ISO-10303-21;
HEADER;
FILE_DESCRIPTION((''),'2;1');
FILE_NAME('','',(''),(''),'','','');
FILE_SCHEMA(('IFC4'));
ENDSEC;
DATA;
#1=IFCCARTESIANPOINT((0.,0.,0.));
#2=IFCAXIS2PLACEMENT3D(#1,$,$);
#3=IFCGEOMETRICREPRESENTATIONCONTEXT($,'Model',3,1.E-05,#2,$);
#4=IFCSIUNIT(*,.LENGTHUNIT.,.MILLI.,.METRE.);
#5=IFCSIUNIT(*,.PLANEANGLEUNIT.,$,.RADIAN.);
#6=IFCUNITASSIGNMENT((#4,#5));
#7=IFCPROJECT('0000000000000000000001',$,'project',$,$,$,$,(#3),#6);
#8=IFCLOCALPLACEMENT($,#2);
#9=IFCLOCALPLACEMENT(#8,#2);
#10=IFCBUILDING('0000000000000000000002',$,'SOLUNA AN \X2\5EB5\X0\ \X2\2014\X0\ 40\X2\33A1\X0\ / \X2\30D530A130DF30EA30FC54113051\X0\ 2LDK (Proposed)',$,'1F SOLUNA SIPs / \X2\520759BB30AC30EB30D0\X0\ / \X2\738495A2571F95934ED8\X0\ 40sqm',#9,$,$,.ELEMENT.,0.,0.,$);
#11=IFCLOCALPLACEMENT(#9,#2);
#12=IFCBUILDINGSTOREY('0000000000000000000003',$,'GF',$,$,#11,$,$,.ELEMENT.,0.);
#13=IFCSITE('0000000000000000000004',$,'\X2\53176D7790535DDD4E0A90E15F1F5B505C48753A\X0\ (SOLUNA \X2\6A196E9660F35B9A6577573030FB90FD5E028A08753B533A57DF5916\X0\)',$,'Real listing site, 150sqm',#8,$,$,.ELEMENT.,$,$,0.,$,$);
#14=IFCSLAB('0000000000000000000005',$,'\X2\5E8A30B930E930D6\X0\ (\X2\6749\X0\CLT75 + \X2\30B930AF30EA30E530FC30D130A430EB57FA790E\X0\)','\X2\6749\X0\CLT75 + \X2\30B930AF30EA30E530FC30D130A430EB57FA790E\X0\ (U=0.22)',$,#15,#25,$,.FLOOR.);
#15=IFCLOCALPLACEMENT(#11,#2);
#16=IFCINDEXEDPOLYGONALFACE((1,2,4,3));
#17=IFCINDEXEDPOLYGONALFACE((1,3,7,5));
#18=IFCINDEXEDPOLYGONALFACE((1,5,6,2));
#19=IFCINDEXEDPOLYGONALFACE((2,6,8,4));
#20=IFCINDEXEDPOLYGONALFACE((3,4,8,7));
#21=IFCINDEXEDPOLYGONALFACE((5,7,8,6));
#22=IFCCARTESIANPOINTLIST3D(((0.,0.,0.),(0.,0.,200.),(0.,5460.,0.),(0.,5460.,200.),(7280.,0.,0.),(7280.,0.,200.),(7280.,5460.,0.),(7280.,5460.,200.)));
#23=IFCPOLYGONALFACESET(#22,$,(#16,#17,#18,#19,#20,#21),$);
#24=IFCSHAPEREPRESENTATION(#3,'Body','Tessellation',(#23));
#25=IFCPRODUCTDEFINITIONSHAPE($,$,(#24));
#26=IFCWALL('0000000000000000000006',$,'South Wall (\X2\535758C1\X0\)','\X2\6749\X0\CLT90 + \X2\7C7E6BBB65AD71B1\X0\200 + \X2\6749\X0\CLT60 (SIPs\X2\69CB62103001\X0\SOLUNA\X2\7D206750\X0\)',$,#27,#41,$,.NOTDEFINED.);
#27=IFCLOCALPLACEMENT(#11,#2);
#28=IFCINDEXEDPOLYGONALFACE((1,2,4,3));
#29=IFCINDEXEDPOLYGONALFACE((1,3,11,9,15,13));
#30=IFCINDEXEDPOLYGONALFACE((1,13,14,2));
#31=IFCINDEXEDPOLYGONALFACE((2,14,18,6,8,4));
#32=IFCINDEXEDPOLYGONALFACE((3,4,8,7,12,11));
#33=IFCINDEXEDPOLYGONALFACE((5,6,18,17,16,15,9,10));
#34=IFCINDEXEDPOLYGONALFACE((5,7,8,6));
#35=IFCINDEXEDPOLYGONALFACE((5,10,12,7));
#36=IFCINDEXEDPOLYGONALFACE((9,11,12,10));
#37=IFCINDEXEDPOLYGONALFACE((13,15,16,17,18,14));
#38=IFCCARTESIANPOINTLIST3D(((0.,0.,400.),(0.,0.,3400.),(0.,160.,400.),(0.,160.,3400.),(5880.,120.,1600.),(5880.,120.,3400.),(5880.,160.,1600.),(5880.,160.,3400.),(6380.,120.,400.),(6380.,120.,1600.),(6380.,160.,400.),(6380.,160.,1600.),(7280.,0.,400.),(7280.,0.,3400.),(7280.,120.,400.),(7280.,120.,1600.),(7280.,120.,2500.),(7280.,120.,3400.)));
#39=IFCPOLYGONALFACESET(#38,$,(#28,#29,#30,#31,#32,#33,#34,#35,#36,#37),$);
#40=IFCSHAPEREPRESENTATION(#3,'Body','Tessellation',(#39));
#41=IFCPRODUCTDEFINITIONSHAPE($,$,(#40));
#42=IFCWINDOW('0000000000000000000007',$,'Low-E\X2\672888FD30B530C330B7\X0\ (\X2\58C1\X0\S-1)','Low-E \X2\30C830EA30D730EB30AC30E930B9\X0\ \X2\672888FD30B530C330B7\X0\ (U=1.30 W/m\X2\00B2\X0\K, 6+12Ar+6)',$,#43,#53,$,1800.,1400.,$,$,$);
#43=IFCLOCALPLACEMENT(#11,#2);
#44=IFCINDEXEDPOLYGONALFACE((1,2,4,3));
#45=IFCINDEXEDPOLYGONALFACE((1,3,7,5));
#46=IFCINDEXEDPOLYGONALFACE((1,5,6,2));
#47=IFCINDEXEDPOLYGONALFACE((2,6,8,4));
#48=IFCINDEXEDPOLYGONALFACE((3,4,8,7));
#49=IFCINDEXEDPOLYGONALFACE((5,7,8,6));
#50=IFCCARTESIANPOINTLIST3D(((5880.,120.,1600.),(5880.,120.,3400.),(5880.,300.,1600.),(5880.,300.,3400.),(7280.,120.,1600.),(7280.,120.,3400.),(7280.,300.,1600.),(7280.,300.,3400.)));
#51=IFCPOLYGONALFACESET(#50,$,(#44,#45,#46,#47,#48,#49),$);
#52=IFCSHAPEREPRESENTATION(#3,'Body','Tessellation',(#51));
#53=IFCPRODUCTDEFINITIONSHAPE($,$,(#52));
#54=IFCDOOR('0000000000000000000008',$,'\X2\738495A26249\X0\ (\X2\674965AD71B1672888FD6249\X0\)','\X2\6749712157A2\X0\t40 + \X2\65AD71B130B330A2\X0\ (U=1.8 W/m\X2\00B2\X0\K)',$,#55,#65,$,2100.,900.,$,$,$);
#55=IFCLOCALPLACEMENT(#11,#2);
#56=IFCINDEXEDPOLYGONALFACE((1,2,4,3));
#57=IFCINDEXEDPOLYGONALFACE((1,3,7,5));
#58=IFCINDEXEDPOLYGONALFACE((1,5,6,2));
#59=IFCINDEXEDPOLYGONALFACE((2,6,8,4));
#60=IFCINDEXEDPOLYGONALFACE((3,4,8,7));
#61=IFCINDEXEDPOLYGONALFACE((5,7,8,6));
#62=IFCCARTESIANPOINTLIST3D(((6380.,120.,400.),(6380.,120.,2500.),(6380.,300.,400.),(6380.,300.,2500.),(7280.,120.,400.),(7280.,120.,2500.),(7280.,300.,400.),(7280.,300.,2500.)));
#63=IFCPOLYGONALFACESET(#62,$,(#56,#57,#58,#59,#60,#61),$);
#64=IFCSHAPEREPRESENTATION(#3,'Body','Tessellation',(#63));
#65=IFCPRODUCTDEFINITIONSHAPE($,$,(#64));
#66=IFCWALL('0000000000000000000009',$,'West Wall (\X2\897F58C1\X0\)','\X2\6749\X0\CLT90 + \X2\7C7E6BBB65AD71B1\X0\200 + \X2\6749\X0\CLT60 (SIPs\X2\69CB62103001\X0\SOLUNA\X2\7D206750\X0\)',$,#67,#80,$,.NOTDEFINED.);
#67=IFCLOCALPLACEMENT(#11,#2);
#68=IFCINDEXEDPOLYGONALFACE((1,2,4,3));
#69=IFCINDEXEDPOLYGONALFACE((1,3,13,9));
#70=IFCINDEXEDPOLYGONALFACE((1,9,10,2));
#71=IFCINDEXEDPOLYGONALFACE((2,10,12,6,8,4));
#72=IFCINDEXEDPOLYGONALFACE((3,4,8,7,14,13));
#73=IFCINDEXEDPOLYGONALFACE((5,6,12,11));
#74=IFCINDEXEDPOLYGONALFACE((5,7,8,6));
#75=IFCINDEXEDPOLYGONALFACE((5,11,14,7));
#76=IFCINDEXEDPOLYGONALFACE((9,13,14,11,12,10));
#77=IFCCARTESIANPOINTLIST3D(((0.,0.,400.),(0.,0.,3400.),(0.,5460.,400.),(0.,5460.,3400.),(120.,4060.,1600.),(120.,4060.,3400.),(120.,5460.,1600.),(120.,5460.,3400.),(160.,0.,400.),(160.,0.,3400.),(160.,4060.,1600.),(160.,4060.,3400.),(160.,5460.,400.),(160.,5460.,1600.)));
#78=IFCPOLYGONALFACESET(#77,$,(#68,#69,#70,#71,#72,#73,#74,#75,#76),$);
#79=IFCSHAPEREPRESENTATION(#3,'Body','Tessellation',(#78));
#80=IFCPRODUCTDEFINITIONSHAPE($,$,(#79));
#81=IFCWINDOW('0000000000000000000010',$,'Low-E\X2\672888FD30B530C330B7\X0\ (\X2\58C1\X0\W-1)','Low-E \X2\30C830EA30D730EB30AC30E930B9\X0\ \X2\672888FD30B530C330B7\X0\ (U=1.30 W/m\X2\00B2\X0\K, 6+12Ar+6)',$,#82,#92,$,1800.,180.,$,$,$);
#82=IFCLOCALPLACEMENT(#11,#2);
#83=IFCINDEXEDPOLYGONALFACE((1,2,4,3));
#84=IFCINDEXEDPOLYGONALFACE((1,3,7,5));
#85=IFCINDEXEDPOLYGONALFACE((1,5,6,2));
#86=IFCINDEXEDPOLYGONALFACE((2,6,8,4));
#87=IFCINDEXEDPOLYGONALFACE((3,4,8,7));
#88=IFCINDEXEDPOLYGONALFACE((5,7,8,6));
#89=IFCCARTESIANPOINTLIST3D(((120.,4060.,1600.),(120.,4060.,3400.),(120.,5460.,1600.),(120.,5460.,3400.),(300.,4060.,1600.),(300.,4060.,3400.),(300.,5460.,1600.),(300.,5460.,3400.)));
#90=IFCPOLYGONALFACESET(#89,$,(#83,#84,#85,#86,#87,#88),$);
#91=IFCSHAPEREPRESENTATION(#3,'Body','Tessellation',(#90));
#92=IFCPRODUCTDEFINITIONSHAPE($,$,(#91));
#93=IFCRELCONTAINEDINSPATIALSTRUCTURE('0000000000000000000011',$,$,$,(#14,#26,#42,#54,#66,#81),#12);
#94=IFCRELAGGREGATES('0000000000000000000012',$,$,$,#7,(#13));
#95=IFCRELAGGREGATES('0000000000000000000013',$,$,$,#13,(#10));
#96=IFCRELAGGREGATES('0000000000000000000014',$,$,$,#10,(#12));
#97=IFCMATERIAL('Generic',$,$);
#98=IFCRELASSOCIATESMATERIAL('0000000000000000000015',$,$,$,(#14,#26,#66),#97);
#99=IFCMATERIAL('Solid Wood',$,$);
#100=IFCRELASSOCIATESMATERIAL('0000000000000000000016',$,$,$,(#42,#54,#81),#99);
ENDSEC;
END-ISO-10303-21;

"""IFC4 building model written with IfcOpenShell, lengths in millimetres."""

from ifc_helpers import new_model, si_unit, frame, frame_2d, origin, place, context, project, spatial, rectangle, extrude, material, element, fill, save


model = new_model("IFC4")

# Units and contexts
model_context = context("Model", 3, precision=1e-05, world=origin())
ifc_project = project(units=[si_unit("LENGTHUNIT", "METRE", prefix="MILLI"), si_unit("PLANEANGLEUNIT", "RADIAN")], contexts=[model_context])

# Site, building, storey
site_placement = place(None, origin())
site = spatial("IfcSite", under=ifc_project, at=site_placement, Name="北海道川上郡弟子屈町 (SOLUNA 標準想定敷地・都市計画区域外)", ObjectType="Real listing site, 150sqm", CompositionType="ELEMENT", RefElevation=0.0)
building_placement = place(site_placement, origin())
building = spatial("IfcBuilding", under=site, at=building_placement, Name="SOLUNA AN 庵 — 40㎡ / ファミリー向け 2LDK (Proposed)", ObjectType="1F SOLUNA SIPs / 切妻ガルバ / 玄関土間付 40sqm", CompositionType="ELEMENT", ElevationOfRefHeight=0.0, ElevationOfTerrain=0.0)
storey_placement = place(building_placement, origin())
storey = spatial("IfcBuildingStorey", under=building, at=storey_placement, Name="GF", CompositionType="ELEMENT", Elevation=0.0)

# Slab
ifc_material_1 = material(Name="Generic")
slab_placement = place(storey_placement, origin())
element("IfcSlab", 1, at=slab_placement, inside=storey, material=ifc_material_1, Name="床スラブ (杉CLT75 + スクリューパイル基礎)", Description="杉CLT75 + スクリューパイル基礎 (U=0.22)", PredefinedType="FLOOR", context=model_context, shape_type="SweptSolid", body=[
    extrude(rectangle(XDim=7280.0, YDim=5460.0, at=frame_2d((3640.0, 2730.0))), origin(), (0.0, 0.0, 1.0), 200.0),
])

# Wall, openings, window, door
wall_1_placement = place(storey_placement, frame((0.0, 0.0, 200.0)))
wall_1 = element("IfcWall", 2, at=wall_1_placement, inside=storey, material=ifc_material_1, Name="South Wall (南壁)", Description="杉CLT90 + 籾殻断熱200 + 杉CLT60 (SIPs構成、SOLUNA素材)", PredefinedType="NOTDEFINED", context=model_context, shape_type="SweptSolid", body=[
    extrude(rectangle(XDim=7280.0, YDim=160.0, at=frame_2d((3640.0, 80.0))), frame((0.0, 0.0, 200.0)), (0.0, 0.0, 1.0), 3000.0),
])
opening_1_placement = place(storey_placement, frame((2940.0, 60.0, 800.0)))
opening_1 = element("IfcOpeningElement", 3, at=opening_1_placement, cuts=wall_1, PredefinedType="NOTDEFINED", context=model_context, shape_type="SweptSolid", body=[
    extrude(rectangle(XDim=1400.0, YDim=180.0, at=frame_2d((700.0, 90.0))), frame((2940.0, 60.0, 800.0)), (0.0, 0.0, 1.0), 1800.0),
])
opening_2_placement = place(storey_placement, frame((3190.0, 60.0, 200.0)))
opening_2 = element("IfcOpeningElement", 4, at=opening_2_placement, cuts=wall_1, PredefinedType="NOTDEFINED", context=model_context, shape_type="SweptSolid", body=[
    extrude(rectangle(XDim=900.0, YDim=180.0, at=frame_2d((450.0, 90.0))), frame((3190.0, 60.0, 200.0)), (0.0, 0.0, 1.0), 2100.0),
])
ifc_material_2 = material(Name="Solid Wood")
window_1_placement = place(storey_placement, frame((2940.0, 60.0, 800.0)))
window_1 = element("IfcWindow", 5, at=window_1_placement, inside=storey, material=ifc_material_2, Name="Low-E木製サッシ (壁S-1)", Description="Low-E トリプルガラス 木製サッシ (U=1.30 W/m²K, 6+12Ar+6)", OverallHeight=1800.0, OverallWidth=1400.0, context=model_context, shape_type="SweptSolid", body=[
    extrude(rectangle(XDim=1400.0, YDim=180.0, at=frame_2d((700.0, 90.0))), frame((2940.0, 60.0, 800.0)), (0.0, 0.0, 1.0), 1800.0),
])
fill(opening_1, window_1)
door_placement = place(storey_placement, frame((3190.0, 60.0, 200.0)))
door = element("IfcDoor", 6, at=door_placement, inside=storey, material=ifc_material_2, Name="玄関扉 (杉断熱木製扉)", Description="杉無垢t40 + 断熱コア (U=1.8 W/m²K)", OverallHeight=2100.0, OverallWidth=900.0, context=model_context, shape_type="SweptSolid", body=[
    extrude(rectangle(XDim=900.0, YDim=180.0, at=frame_2d((450.0, 90.0))), frame((3190.0, 60.0, 200.0)), (0.0, 0.0, 1.0), 2100.0),
])
fill(opening_2, door)

# Wall, opening, window
wall_2_placement = place(storey_placement, frame((0.0, 0.0, 200.0)))
wall_2 = element("IfcWall", 7, at=wall_2_placement, inside=storey, material=ifc_material_1, Name="West Wall (西壁)", Description="杉CLT90 + 籾殻断熱200 + 杉CLT60 (SIPs構成、SOLUNA素材)", PredefinedType="NOTDEFINED", context=model_context, shape_type="SweptSolid", body=[
    extrude(rectangle(XDim=160.0, YDim=5460.0, at=frame_2d((80.0, 2730.0))), frame((0.0, 0.0, 200.0)), (0.0, 0.0, 1.0), 3000.0),
])
opening_3_placement = place(storey_placement, frame((60.0, 2030.0, 800.0)))
opening_3 = element("IfcOpeningElement", 8, at=opening_3_placement, cuts=wall_2, PredefinedType="NOTDEFINED", context=model_context, shape_type="SweptSolid", body=[
    extrude(rectangle(XDim=180.0, YDim=1400.0, at=frame_2d((90.0, 700.0))), frame((60.0, 2030.0, 800.0)), (0.0, 0.0, 1.0), 1800.0),
])
window_2_placement = place(storey_placement, frame((60.0, 2030.0, 800.0)))
window_2 = element("IfcWindow", 9, at=window_2_placement, inside=storey, material=ifc_material_2, Name="Low-E木製サッシ (壁W-1)", Description="Low-E トリプルガラス 木製サッシ (U=1.30 W/m²K, 6+12Ar+6)", OverallHeight=1800.0, OverallWidth=180.0, context=model_context, shape_type="SweptSolid", body=[
    extrude(rectangle(XDim=180.0, YDim=1400.0, at=frame_2d((90.0, 700.0))), frame((60.0, 2030.0, 800.0)), (0.0, 0.0, 1.0), 1800.0),
])
fill(opening_3, window_2)

save(model, "model.ifc")
